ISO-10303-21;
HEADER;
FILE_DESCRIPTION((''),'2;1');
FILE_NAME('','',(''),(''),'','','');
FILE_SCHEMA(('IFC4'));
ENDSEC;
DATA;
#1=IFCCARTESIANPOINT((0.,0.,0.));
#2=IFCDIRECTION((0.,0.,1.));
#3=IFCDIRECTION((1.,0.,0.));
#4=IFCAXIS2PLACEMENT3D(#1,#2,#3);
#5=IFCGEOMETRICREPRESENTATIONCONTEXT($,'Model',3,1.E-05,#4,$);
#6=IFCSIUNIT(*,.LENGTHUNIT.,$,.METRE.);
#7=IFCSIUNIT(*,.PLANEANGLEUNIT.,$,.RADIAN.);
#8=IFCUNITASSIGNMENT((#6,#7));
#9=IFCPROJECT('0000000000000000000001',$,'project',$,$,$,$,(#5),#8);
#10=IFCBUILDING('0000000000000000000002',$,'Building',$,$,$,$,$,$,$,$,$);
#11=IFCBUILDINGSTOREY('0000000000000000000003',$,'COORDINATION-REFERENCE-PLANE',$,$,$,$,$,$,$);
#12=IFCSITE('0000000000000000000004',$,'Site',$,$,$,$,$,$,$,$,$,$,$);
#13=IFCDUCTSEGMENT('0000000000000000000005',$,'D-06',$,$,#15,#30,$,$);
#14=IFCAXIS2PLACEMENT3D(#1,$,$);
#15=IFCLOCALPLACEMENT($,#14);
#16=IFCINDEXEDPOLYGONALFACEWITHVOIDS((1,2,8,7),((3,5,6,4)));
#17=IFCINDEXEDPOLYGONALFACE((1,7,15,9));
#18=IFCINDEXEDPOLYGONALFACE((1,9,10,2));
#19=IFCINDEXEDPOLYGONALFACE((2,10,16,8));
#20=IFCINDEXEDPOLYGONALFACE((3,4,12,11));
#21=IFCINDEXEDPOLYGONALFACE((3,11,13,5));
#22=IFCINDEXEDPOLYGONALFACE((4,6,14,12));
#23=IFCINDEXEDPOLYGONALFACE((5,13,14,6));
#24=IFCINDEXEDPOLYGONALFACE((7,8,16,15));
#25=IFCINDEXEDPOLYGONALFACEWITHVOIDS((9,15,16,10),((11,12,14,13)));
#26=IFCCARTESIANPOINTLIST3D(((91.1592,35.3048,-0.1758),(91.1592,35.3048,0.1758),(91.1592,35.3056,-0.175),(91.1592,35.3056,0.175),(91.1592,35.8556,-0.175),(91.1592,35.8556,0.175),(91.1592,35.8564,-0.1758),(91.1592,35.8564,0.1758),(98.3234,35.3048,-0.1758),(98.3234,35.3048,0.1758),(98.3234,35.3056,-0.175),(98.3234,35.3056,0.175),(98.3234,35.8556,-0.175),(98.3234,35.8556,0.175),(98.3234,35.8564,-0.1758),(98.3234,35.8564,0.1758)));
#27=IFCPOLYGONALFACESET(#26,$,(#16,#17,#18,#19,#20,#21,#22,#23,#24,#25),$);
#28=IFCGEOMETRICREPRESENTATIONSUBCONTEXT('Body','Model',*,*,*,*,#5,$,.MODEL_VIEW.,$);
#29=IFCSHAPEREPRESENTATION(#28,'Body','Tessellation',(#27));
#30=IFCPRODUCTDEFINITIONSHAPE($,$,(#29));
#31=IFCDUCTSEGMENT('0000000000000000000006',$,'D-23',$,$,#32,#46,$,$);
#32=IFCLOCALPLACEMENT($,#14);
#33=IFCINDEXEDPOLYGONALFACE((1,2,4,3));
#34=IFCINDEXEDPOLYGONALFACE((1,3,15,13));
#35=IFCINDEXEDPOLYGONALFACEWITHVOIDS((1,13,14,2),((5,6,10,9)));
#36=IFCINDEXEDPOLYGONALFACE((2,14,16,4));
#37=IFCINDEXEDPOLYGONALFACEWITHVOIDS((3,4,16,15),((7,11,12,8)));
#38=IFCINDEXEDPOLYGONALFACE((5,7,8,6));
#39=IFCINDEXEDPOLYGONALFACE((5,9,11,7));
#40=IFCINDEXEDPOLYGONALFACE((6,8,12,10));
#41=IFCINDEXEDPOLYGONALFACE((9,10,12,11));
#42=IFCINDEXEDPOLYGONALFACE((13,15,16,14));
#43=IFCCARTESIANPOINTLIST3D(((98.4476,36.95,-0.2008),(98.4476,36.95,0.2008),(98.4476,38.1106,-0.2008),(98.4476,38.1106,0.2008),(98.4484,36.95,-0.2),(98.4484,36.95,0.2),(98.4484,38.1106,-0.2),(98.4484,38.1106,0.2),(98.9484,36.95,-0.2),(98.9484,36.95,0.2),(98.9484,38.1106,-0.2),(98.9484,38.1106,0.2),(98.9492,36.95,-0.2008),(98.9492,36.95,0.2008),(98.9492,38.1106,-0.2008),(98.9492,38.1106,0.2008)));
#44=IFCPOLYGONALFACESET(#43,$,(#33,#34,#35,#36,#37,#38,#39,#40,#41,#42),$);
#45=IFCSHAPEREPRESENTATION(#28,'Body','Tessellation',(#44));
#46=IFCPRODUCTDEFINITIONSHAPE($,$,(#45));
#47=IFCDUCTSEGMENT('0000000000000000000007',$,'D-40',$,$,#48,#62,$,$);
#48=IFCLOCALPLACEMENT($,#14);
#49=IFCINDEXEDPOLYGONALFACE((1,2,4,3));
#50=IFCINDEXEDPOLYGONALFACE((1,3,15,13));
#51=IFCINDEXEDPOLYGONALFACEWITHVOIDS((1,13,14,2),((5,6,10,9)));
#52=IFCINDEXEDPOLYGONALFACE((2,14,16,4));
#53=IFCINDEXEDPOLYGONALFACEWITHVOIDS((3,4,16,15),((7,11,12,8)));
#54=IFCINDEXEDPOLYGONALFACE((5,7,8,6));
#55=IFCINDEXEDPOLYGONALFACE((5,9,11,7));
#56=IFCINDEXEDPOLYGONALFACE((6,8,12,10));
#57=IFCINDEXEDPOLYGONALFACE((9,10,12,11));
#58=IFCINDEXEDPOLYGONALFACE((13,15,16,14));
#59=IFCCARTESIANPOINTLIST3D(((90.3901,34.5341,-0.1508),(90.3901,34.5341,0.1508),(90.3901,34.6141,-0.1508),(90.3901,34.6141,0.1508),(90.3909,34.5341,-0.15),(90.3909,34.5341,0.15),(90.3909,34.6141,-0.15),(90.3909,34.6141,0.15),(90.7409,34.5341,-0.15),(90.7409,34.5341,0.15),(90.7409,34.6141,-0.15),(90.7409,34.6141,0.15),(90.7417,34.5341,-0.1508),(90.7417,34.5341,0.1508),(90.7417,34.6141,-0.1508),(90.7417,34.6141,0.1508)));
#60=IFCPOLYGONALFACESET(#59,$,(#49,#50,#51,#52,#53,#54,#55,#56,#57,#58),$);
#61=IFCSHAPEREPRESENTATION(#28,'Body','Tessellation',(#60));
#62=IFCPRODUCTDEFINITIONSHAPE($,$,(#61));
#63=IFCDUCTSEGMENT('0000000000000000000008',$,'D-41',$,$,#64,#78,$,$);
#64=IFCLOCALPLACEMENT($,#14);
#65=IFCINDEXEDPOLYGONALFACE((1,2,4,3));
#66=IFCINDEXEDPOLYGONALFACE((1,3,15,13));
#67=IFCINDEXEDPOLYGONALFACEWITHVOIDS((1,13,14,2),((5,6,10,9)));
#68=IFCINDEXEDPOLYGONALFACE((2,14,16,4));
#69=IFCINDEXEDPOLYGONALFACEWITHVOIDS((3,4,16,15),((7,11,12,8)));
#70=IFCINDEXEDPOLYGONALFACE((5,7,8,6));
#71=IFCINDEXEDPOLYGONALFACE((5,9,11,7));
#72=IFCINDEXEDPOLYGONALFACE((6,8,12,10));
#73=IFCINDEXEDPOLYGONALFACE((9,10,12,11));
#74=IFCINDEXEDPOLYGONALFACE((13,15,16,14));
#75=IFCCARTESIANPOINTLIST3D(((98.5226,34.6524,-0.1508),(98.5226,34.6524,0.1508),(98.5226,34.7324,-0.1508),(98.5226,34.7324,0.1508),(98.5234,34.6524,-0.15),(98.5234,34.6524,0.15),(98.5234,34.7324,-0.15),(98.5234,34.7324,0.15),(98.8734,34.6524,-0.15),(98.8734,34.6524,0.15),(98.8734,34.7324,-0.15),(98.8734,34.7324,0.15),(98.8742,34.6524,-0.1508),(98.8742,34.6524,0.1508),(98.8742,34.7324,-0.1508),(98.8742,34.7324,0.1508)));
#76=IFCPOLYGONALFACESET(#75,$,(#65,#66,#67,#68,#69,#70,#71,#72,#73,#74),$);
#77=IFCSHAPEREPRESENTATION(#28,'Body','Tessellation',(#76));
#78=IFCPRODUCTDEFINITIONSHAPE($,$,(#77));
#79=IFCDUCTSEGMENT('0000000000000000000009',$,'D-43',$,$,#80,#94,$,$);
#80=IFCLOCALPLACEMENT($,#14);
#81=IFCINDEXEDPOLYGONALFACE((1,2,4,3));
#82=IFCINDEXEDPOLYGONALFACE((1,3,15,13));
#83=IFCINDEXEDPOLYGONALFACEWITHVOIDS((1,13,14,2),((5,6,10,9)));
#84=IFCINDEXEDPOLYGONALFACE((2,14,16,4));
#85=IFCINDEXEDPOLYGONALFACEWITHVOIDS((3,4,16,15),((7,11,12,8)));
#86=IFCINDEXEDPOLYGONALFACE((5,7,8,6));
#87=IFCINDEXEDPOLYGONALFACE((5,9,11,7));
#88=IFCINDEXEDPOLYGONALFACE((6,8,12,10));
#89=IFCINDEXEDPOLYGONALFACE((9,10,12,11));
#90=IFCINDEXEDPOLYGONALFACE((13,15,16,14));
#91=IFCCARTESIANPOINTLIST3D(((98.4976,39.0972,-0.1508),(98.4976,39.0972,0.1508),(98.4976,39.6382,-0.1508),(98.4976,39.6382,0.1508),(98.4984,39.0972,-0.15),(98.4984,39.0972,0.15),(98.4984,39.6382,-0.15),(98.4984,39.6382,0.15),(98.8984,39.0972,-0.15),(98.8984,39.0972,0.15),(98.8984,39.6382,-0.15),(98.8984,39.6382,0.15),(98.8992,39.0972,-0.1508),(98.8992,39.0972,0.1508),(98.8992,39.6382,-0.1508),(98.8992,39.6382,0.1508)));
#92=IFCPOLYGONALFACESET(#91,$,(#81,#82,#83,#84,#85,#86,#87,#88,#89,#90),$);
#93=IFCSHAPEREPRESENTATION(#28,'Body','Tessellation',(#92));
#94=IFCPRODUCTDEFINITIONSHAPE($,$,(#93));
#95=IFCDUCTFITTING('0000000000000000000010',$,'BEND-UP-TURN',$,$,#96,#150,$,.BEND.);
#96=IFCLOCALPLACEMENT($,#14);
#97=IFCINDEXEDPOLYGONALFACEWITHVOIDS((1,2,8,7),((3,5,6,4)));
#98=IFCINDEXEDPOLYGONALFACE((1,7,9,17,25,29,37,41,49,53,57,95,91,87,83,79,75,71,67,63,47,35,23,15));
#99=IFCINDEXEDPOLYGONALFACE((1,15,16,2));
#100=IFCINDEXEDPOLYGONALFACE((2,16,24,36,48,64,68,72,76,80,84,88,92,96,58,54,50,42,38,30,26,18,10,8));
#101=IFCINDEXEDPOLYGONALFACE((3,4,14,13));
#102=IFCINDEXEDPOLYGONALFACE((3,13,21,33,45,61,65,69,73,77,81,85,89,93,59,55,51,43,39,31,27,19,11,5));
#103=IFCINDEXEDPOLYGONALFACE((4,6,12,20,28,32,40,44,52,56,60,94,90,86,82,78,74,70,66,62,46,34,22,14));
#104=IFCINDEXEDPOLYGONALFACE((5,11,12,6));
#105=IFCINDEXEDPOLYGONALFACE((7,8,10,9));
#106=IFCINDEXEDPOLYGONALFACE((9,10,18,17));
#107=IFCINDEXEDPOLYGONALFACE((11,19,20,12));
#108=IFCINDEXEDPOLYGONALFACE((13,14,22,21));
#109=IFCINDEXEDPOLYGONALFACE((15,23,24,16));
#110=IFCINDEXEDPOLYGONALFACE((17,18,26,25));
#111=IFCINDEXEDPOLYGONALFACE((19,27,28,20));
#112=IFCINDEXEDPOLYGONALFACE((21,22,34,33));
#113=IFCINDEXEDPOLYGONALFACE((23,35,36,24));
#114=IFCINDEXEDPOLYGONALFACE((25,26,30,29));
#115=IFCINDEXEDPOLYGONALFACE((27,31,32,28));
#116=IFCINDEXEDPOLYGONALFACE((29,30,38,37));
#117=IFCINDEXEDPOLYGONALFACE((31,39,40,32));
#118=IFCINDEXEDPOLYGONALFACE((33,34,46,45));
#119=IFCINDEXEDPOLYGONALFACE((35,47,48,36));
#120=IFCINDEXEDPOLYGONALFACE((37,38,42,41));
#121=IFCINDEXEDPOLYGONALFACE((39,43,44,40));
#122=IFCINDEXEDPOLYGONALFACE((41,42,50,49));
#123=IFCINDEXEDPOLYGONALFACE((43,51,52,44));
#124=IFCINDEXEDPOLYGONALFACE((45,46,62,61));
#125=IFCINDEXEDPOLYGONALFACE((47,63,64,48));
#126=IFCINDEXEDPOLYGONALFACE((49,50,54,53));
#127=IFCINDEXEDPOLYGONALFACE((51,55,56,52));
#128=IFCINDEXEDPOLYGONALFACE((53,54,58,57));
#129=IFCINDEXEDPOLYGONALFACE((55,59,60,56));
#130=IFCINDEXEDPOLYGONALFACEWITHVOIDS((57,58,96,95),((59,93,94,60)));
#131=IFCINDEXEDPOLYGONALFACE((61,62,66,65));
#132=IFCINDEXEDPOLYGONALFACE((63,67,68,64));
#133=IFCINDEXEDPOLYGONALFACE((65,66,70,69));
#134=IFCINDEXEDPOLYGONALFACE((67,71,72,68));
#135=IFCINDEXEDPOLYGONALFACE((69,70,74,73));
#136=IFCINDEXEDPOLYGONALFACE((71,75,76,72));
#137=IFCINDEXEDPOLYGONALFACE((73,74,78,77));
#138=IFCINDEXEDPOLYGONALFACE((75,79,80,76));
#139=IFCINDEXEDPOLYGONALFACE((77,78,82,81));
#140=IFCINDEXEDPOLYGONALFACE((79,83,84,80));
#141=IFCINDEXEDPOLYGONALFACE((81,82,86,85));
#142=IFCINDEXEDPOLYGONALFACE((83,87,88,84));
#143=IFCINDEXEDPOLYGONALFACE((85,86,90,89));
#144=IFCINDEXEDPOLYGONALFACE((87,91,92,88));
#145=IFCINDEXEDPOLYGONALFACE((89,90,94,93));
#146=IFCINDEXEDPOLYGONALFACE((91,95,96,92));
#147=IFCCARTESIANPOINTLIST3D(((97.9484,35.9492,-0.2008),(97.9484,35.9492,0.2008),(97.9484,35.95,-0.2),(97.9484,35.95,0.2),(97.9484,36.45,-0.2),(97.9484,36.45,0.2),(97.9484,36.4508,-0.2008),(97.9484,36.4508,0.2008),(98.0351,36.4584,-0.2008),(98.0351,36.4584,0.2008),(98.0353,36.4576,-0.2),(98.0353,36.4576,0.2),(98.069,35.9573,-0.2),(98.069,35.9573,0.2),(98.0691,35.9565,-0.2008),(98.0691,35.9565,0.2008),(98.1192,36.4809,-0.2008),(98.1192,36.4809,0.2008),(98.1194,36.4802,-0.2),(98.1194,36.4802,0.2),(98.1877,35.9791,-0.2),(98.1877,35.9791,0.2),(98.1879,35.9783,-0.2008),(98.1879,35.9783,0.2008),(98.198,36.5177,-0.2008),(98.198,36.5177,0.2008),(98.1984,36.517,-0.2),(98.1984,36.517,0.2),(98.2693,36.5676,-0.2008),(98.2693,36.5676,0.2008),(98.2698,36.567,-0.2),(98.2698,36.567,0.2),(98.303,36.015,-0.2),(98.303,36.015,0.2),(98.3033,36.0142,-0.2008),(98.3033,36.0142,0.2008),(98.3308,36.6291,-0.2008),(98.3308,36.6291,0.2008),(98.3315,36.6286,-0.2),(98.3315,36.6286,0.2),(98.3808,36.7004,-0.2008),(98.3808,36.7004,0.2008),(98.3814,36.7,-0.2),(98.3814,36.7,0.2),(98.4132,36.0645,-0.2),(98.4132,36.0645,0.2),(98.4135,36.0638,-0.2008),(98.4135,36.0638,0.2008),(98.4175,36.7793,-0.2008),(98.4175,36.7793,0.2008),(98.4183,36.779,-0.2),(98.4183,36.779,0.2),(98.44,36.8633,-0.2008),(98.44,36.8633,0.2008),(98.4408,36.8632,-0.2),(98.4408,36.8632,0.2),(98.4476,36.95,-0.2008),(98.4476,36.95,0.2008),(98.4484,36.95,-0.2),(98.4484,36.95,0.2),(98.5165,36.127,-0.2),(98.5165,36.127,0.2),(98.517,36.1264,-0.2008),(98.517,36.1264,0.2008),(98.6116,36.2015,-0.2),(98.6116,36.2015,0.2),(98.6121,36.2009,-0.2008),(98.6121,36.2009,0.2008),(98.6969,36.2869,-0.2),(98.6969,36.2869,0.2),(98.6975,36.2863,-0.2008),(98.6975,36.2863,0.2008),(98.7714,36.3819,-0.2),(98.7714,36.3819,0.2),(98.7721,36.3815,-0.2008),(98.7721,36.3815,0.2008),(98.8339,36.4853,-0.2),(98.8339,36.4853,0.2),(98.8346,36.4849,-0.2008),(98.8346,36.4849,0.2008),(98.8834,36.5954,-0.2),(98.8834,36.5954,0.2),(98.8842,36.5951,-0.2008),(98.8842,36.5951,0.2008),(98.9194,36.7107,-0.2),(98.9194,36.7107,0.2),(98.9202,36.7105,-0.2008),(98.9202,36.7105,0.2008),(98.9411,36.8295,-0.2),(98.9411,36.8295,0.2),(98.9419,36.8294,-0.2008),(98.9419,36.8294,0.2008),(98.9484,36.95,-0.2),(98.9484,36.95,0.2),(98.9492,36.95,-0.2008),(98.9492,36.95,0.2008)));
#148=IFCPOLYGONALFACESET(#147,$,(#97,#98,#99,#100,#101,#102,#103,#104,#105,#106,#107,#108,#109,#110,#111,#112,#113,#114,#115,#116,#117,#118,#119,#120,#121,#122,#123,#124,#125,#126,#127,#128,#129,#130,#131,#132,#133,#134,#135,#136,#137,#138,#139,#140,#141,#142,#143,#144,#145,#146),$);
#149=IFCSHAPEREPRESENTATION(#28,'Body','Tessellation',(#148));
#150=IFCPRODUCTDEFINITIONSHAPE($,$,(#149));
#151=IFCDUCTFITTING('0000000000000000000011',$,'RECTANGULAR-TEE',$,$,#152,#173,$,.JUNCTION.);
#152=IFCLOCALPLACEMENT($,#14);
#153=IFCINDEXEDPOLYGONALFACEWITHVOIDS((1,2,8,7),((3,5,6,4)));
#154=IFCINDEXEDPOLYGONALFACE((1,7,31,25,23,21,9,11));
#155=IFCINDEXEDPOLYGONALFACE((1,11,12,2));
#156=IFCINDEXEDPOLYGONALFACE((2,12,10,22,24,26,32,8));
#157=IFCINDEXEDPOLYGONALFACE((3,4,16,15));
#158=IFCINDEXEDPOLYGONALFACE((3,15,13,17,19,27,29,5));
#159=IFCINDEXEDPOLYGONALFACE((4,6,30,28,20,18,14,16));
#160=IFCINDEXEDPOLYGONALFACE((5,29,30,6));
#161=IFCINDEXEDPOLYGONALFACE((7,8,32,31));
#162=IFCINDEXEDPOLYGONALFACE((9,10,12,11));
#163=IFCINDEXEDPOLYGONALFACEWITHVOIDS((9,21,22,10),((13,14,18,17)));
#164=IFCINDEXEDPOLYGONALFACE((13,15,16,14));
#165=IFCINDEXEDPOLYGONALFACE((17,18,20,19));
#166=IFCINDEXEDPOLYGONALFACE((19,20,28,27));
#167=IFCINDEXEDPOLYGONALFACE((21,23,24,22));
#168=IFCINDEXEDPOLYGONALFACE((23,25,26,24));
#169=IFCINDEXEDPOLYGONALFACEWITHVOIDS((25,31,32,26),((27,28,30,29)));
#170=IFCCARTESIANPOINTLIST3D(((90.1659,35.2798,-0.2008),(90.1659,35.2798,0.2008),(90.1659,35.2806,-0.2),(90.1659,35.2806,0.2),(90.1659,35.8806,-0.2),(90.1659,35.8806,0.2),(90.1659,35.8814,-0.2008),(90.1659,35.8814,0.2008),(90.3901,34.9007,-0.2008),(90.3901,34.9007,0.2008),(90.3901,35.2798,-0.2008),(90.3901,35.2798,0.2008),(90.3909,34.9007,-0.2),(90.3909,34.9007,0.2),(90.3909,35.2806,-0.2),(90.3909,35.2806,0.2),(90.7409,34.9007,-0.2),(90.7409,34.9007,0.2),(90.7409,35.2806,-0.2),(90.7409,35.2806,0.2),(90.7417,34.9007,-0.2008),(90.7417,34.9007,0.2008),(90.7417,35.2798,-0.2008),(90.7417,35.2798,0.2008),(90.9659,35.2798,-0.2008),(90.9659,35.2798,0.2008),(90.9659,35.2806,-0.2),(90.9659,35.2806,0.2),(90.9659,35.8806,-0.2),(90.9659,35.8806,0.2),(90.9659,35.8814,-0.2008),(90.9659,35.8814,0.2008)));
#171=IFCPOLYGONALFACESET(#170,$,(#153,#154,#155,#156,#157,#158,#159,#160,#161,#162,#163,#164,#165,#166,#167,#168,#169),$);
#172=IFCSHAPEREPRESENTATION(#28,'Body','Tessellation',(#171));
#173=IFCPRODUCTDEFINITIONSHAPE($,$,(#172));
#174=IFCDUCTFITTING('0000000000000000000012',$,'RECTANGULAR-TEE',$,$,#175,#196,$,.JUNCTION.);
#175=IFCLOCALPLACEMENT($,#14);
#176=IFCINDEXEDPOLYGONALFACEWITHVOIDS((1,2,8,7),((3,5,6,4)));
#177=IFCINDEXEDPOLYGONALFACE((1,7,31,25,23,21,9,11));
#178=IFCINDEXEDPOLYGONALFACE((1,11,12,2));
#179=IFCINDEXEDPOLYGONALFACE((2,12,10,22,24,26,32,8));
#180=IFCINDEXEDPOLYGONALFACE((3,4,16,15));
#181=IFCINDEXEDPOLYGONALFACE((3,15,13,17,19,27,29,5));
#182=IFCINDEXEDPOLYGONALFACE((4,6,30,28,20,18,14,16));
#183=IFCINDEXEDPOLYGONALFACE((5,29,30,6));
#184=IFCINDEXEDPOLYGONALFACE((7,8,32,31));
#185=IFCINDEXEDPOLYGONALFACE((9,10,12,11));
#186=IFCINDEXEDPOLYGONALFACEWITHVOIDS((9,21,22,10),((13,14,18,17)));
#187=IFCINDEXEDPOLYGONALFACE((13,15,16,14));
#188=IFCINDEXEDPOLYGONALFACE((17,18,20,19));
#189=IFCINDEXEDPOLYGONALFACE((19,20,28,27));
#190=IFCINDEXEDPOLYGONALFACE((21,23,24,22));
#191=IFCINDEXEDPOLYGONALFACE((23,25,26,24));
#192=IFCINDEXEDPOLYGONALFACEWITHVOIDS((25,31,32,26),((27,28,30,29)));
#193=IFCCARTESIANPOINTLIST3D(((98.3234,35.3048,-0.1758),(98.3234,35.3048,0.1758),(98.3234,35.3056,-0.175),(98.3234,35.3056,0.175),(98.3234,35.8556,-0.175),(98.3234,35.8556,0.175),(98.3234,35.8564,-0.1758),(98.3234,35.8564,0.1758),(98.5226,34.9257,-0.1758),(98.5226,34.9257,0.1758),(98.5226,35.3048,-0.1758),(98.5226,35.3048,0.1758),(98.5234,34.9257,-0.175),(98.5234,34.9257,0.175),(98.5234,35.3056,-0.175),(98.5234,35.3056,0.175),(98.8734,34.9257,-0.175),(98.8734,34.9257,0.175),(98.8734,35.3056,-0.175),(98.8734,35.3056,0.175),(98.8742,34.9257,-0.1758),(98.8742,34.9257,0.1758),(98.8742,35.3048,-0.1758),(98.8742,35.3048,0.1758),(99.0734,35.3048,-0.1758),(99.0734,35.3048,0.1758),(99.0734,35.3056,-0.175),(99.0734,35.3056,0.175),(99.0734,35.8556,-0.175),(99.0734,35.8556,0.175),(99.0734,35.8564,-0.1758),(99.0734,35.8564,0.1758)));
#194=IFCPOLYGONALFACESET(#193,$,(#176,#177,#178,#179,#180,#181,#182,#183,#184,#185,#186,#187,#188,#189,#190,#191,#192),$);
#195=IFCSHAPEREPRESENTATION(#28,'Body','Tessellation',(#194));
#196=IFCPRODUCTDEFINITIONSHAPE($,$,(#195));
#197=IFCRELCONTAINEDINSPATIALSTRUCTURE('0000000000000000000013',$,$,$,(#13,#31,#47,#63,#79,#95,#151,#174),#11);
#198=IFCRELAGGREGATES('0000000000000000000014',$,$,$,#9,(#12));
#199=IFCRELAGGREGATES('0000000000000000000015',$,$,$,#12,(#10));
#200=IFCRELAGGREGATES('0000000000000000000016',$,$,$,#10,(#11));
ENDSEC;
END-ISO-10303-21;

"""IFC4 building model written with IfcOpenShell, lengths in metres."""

from ifc_helpers import new_model, entity, si_unit, frame, origin, origin_with_axes, place, context, subcontext, project, spatial, rectangle, hollow_rectangle, extrude, boolean, element, save


model = new_model("IFC4")

# Units and contexts
model_context = context("Model", 3, precision=1e-05, world=origin_with_axes())
body_context_1 = subcontext(model_context, "Body", "Model", "MODEL_VIEW")
ifc_project = project(units=[si_unit("LENGTHUNIT", "METRE"), si_unit("PLANEANGLEUNIT", "RADIAN")], contexts=[model_context])

# Site, building, storey
site = spatial("IfcSite", under=ifc_project, Name="Site")
building = spatial("IfcBuilding", under=site, Name="Building")
storey = spatial("IfcBuildingStorey", under=building, Name="COORDINATION-REFERENCE-PLANE")

# Duct segments
duct_segment_1_placement = place(None, frame((91.1592, 35.5806, 0.0), z_axis=(1.0, 0.0, 0.0), x_axis=(0.0, 1.0, 0.0)))
element("IfcDuctSegment", 1, at=duct_segment_1_placement, inside=storey, Name="D-06", context=body_context_1, shape_type="SweptSolid", body=[
    extrude(hollow_rectangle(XDim=0.5516, YDim=0.3516, WallThickness=0.0008), origin(), (0.0, 0.0, 1.0), 7.1642),
])
duct_segment_2_placement = place(None, frame((98.6984, 36.95, 0.0), z_axis=(0.0, 1.0, 0.0), x_axis=(1.0, 0.0, 0.0)))
element("IfcDuctSegment", 2, at=duct_segment_2_placement, inside=storey, Name="D-23", context=body_context_1, shape_type="SweptSolid", body=[
    extrude(hollow_rectangle(XDim=0.5016, YDim=0.4016, WallThickness=0.0008), origin(), (0.0, 0.0, 1.0), 1.1606),
])
for number, where, z_axis, x_axis, name in (
    (3, (90.5659, 34.5341, 0.0), (0.0, 1.0, 0.0), (1.0, 0.0, 0.0), "D-40"),
    (4, (98.6984, 34.6524, 0.0), (0.0, 1.0, 0.0), (1.0, 0.0, 0.0), "D-41"),
):
    element("IfcDuctSegment", number, at=place(None, frame(where, z_axis=z_axis, x_axis=x_axis)), inside=storey, Name=name, context=body_context_1, shape_type="SweptSolid", body=[
        extrude(hollow_rectangle(XDim=0.3516, YDim=0.3016, WallThickness=0.0008), origin(), (0.0, 0.0, 1.0), 0.08),
    ])
duct_segment_3_placement = place(None, frame((98.6984, 39.0972, 0.0), z_axis=(0.0, 1.0, 0.0), x_axis=(1.0, 0.0, 0.0)))
element("IfcDuctSegment", 5, at=duct_segment_3_placement, inside=storey, Name="D-43", context=body_context_1, shape_type="SweptSolid", body=[
    extrude(hollow_rectangle(XDim=0.4016, YDim=0.3016, WallThickness=0.0008), origin(), (0.0, 0.0, 1.0), 0.541),
])

# Duct fittings
duct_fitting_1_placement = place(None, frame((97.9484, 36.95, 0.0), z_axis=(0.0, 0.0, 1.0), x_axis=(0.0, -1.0, 0.0)))
cartesian_point = entity("IfcCartesianPoint", [0.0, 0.0, 0.0])
element("IfcDuctFitting", 6, at=duct_fitting_1_placement, inside=storey, Name="BEND-UP-TURN", PredefinedType="BEND", context=body_context_1, shape_type="SweptSolid", body=[
    entity("IfcRevolvedAreaSolid", entity("IfcRectangleHollowProfileDef", "AREA", None, entity("IfcAxis2Placement2D", entity("IfcCartesianPoint", [0.75, 0.0])), 0.5016, 0.4016, 0.0008), entity("IfcAxis2Placement3D", cartesian_point, entity("IfcDirection", [0.0, -1.0, 0.0]), entity("IfcDirection", [1.0, 0.0, 0.0])), entity("IfcAxis1Placement", cartesian_point, entity("IfcDirection", [0.0, 1.0, 0.0])), 1.570796),
])
duct_fitting_2_placement = place(None, frame((90.5659, 35.5806, 0.0), z_axis=(1.0, 0.0, 0.0), x_axis=(0.0, -1.0, 0.0)))
solid_1 = boolean("UNION", extrude(rectangle(XDim=0.6, YDim=0.4), frame((0.0, 0.0, -0.4), z_axis=(0.0, 0.0, 1.0), x_axis=(1.0, 0.0, 0.0)), (0.0, 0.0, 1.0), 0.8), extrude(rectangle(XDim=0.35, YDim=0.4), frame((0.0, 0.0, 0.0), z_axis=(1.0, 0.0, 0.0), x_axis=(0.0, 0.0, -1.0)), (0.0, 0.0, 1.0), 0.6799))
element("IfcDuctFitting", 7, at=duct_fitting_2_placement, inside=storey, Name="RECTANGULAR-TEE", PredefinedType="JUNCTION", context=body_context_1, shape_type="CSG", body=[
    boolean("DIFFERENCE", boolean("UNION", extrude(rectangle(XDim=0.6016, YDim=0.4016), frame((0.0, 0.0, -0.4), z_axis=(0.0, 0.0, 1.0), x_axis=(1.0, 0.0, 0.0)), (0.0, 0.0, 1.0), 0.8), extrude(rectangle(XDim=0.3516, YDim=0.4016), frame((0.0, 0.0, 0.0), z_axis=(1.0, 0.0, 0.0), x_axis=(0.0, 0.0, -1.0)), (0.0, 0.0, 1.0), 0.6799)), solid_1),
])
duct_fitting_3_placement = place(None, frame((98.6984, 35.5806, 0.0), z_axis=(1.0, 0.0, 0.0), x_axis=(0.0, -1.0, 0.0)))
solid_2 = boolean("UNION", extrude(rectangle(XDim=0.55, YDim=0.35), frame((0.0, 0.0, -0.375), z_axis=(0.0, 0.0, 1.0), x_axis=(1.0, 0.0, 0.0)), (0.0, 0.0, 1.0), 0.75), extrude(rectangle(XDim=0.35, YDim=0.35), frame((0.0, 0.0, 0.0), z_axis=(1.0, 0.0, 0.0), x_axis=(0.0, 0.0, -1.0)), (0.0, 0.0, 1.0), 0.6549))
element("IfcDuctFitting", 8, at=duct_fitting_3_placement, inside=storey, Name="RECTANGULAR-TEE", PredefinedType="JUNCTION", context=body_context_1, shape_type="CSG", body=[
    boolean("DIFFERENCE", boolean("UNION", extrude(rectangle(XDim=0.5516, YDim=0.3516), frame((0.0, 0.0, -0.375), z_axis=(0.0, 0.0, 1.0), x_axis=(1.0, 0.0, 0.0)), (0.0, 0.0, 1.0), 0.75), extrude(rectangle(XDim=0.3516, YDim=0.3516), frame((0.0, 0.0, 0.0), z_axis=(1.0, 0.0, 0.0), x_axis=(0.0, 0.0, -1.0)), (0.0, 0.0, 1.0), 0.6549)), solid_2),
])

save(model, "model.ifc")
